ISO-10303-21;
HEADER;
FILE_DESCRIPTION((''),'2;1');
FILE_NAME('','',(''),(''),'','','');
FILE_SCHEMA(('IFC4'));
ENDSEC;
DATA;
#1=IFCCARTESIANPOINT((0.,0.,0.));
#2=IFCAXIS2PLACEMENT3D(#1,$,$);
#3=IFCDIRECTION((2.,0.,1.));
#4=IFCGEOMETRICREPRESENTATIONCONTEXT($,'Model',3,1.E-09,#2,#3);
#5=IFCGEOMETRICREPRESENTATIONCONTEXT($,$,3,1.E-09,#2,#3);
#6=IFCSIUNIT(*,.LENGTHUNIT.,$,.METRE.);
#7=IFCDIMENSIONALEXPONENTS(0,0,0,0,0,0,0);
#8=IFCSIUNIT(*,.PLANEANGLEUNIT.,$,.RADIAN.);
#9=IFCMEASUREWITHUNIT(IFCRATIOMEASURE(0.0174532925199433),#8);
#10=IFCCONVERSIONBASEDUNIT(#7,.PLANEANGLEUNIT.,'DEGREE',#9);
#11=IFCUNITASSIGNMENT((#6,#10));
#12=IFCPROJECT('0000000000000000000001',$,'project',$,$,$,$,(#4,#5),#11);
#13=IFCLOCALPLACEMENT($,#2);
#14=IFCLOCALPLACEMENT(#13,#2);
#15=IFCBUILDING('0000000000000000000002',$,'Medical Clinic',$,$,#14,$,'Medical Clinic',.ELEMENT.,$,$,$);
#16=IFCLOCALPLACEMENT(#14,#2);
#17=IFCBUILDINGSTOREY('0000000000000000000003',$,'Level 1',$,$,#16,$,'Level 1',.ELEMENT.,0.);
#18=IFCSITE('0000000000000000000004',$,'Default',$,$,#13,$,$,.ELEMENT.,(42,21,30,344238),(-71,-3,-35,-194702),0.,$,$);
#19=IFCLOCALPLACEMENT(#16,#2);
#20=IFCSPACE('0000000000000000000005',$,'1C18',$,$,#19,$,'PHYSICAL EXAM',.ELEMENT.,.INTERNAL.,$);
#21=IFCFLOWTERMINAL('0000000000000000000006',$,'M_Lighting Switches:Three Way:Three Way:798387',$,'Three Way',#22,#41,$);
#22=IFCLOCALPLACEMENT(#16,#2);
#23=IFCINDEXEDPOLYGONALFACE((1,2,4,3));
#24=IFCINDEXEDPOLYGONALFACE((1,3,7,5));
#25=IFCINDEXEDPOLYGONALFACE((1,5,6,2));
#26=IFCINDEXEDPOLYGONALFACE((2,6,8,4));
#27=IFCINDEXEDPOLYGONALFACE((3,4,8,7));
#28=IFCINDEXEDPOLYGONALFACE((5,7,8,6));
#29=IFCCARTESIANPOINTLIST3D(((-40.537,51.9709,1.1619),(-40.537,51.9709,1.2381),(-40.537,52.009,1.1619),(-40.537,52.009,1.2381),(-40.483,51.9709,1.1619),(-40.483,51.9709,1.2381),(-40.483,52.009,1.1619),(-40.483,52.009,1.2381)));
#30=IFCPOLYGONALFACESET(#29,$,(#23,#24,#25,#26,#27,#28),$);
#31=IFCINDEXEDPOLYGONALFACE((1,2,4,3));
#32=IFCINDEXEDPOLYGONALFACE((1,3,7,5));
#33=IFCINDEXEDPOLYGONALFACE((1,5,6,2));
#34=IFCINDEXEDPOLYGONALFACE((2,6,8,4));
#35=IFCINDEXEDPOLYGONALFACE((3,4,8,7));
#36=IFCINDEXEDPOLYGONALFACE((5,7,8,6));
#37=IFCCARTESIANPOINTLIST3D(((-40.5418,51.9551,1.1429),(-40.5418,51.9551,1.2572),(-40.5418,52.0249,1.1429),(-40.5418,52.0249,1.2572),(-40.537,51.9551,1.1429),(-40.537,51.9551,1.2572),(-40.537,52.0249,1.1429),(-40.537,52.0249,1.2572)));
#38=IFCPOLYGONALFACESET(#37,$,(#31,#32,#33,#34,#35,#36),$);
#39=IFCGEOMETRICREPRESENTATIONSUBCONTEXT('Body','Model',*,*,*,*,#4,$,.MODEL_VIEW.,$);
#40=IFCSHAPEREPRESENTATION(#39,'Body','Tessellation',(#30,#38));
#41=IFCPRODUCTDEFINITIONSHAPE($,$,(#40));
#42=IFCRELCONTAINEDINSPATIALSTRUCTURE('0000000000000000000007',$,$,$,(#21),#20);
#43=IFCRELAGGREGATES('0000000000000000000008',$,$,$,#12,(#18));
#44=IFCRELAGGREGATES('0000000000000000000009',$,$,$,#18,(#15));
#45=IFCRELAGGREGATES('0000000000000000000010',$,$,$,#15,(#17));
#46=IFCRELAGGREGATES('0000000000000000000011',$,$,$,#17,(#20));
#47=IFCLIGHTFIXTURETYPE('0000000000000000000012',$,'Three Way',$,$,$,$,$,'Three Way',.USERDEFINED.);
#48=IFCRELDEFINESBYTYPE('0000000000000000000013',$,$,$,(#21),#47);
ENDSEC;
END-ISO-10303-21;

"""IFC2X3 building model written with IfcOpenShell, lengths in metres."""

from ifc_helpers import new_model, entity, si_unit, converted_unit, direction, frame, frame_2d, origin, origin_2d_with_axis, place, context, subcontext, project, spatial, rectangle, extrude, source, transform, mapped, type_object, type_shapes, element, save


model = new_model("IFC2X3")

# Units and contexts
model_context = context("Model", 3, precision=1e-09, world=origin(), true_north=direction((2.0, 0.0, 1.0)))
context_of_model = context(None, 3, precision=1e-09, world=origin(), true_north=direction((2.0, 0.0, 1.0)))
body_context = subcontext(model_context, "Body", "Model", "MODEL_VIEW")
ifc_project = project(units=[si_unit("LENGTHUNIT", "METRE"), converted_unit("PLANEANGLEUNIT", "DEGREE", entity("IfcRatioMeasure", 0.0174532925199433), si_unit("PLANEANGLEUNIT", "RADIAN"), dimensions=[0, 0, 0, 0, 0, 0, 0])], contexts=[model_context, context_of_model])

# Site, building, storey
site_placement = place(None, origin())
site = spatial("IfcSite", under=ifc_project, at=site_placement, Name="Default", CompositionType="ELEMENT", RefLatitude=(42, 21, 30, 344238), RefLongitude=(-71, -3, -35, -194702), RefElevation=0.0)
building_placement = place(site_placement, origin())
building = spatial("IfcBuilding", under=site, at=building_placement, Name="Medical Clinic", LongName="Medical Clinic", CompositionType="ELEMENT")
storey_placement = place(building_placement, origin())
storey = spatial("IfcBuildingStorey", under=building, at=storey_placement, Name="Level 1", LongName="Level 1", CompositionType="ELEMENT", Elevation=0.0)

# Shared definitions
space_1_placement = place(storey_placement, origin())
space_1 = spatial("IfcSpace", under=storey, at=space_1_placement, Name="1C18", LongName="PHYSICAL EXAM", CompositionType="ELEMENT", InteriorOrExteriorSpace="INTERNAL")

# Flow terminal
light_fixture_type_1 = type_object("IfcLightFixtureType", Name="Three Way", ElementType="Three Way", PredefinedType="USERDEFINED")
shared_shape_1 = source(origin(), body_context, "Body", "SweptSolid", [
    extrude(rectangle(XDim=0.0381, YDim=0.0762, at=origin_2d_with_axis()), frame((0.0, 0.0, -0.054), z_axis=(0.0, 0.0, 1.0), x_axis=(-1.0, 0.0, 0.0)), (0.0, 0.0, 1.0), 0.054),
    extrude(rectangle(XDim=0.0698, YDim=0.1143, at=frame_2d((0.0, 0.0), x_axis=(1.0, 0.0))), frame((0.0, 0.0, 0.0), z_axis=(0.0, 0.0, 1.0), x_axis=(-1.0, 0.0, 0.0)), (0.0, 0.0, 1.0), 0.0048),
])
type_shapes(light_fixture_type_1, [shared_shape_1])
flow_terminal_1_placement = place(space_1_placement, frame((-40.537, 51.99, 1.2), z_axis=(-1.0, 0.0, 0.0), x_axis=(0.0, -1.0, 0.0)))
element("IfcFlowTerminal", 1, at=flow_terminal_1_placement, inside=space_1, type_object=light_fixture_type_1, Name="M_Lighting Switches:Three Way:Three Way:798387", ObjectType="Three Way", context=body_context, shape_type="MappedRepresentation", body=[
    mapped(shared_shape_1, transform((0.0, 0.0, 0.0), scale=1.0)),
])

save(model, "model.ifc")
